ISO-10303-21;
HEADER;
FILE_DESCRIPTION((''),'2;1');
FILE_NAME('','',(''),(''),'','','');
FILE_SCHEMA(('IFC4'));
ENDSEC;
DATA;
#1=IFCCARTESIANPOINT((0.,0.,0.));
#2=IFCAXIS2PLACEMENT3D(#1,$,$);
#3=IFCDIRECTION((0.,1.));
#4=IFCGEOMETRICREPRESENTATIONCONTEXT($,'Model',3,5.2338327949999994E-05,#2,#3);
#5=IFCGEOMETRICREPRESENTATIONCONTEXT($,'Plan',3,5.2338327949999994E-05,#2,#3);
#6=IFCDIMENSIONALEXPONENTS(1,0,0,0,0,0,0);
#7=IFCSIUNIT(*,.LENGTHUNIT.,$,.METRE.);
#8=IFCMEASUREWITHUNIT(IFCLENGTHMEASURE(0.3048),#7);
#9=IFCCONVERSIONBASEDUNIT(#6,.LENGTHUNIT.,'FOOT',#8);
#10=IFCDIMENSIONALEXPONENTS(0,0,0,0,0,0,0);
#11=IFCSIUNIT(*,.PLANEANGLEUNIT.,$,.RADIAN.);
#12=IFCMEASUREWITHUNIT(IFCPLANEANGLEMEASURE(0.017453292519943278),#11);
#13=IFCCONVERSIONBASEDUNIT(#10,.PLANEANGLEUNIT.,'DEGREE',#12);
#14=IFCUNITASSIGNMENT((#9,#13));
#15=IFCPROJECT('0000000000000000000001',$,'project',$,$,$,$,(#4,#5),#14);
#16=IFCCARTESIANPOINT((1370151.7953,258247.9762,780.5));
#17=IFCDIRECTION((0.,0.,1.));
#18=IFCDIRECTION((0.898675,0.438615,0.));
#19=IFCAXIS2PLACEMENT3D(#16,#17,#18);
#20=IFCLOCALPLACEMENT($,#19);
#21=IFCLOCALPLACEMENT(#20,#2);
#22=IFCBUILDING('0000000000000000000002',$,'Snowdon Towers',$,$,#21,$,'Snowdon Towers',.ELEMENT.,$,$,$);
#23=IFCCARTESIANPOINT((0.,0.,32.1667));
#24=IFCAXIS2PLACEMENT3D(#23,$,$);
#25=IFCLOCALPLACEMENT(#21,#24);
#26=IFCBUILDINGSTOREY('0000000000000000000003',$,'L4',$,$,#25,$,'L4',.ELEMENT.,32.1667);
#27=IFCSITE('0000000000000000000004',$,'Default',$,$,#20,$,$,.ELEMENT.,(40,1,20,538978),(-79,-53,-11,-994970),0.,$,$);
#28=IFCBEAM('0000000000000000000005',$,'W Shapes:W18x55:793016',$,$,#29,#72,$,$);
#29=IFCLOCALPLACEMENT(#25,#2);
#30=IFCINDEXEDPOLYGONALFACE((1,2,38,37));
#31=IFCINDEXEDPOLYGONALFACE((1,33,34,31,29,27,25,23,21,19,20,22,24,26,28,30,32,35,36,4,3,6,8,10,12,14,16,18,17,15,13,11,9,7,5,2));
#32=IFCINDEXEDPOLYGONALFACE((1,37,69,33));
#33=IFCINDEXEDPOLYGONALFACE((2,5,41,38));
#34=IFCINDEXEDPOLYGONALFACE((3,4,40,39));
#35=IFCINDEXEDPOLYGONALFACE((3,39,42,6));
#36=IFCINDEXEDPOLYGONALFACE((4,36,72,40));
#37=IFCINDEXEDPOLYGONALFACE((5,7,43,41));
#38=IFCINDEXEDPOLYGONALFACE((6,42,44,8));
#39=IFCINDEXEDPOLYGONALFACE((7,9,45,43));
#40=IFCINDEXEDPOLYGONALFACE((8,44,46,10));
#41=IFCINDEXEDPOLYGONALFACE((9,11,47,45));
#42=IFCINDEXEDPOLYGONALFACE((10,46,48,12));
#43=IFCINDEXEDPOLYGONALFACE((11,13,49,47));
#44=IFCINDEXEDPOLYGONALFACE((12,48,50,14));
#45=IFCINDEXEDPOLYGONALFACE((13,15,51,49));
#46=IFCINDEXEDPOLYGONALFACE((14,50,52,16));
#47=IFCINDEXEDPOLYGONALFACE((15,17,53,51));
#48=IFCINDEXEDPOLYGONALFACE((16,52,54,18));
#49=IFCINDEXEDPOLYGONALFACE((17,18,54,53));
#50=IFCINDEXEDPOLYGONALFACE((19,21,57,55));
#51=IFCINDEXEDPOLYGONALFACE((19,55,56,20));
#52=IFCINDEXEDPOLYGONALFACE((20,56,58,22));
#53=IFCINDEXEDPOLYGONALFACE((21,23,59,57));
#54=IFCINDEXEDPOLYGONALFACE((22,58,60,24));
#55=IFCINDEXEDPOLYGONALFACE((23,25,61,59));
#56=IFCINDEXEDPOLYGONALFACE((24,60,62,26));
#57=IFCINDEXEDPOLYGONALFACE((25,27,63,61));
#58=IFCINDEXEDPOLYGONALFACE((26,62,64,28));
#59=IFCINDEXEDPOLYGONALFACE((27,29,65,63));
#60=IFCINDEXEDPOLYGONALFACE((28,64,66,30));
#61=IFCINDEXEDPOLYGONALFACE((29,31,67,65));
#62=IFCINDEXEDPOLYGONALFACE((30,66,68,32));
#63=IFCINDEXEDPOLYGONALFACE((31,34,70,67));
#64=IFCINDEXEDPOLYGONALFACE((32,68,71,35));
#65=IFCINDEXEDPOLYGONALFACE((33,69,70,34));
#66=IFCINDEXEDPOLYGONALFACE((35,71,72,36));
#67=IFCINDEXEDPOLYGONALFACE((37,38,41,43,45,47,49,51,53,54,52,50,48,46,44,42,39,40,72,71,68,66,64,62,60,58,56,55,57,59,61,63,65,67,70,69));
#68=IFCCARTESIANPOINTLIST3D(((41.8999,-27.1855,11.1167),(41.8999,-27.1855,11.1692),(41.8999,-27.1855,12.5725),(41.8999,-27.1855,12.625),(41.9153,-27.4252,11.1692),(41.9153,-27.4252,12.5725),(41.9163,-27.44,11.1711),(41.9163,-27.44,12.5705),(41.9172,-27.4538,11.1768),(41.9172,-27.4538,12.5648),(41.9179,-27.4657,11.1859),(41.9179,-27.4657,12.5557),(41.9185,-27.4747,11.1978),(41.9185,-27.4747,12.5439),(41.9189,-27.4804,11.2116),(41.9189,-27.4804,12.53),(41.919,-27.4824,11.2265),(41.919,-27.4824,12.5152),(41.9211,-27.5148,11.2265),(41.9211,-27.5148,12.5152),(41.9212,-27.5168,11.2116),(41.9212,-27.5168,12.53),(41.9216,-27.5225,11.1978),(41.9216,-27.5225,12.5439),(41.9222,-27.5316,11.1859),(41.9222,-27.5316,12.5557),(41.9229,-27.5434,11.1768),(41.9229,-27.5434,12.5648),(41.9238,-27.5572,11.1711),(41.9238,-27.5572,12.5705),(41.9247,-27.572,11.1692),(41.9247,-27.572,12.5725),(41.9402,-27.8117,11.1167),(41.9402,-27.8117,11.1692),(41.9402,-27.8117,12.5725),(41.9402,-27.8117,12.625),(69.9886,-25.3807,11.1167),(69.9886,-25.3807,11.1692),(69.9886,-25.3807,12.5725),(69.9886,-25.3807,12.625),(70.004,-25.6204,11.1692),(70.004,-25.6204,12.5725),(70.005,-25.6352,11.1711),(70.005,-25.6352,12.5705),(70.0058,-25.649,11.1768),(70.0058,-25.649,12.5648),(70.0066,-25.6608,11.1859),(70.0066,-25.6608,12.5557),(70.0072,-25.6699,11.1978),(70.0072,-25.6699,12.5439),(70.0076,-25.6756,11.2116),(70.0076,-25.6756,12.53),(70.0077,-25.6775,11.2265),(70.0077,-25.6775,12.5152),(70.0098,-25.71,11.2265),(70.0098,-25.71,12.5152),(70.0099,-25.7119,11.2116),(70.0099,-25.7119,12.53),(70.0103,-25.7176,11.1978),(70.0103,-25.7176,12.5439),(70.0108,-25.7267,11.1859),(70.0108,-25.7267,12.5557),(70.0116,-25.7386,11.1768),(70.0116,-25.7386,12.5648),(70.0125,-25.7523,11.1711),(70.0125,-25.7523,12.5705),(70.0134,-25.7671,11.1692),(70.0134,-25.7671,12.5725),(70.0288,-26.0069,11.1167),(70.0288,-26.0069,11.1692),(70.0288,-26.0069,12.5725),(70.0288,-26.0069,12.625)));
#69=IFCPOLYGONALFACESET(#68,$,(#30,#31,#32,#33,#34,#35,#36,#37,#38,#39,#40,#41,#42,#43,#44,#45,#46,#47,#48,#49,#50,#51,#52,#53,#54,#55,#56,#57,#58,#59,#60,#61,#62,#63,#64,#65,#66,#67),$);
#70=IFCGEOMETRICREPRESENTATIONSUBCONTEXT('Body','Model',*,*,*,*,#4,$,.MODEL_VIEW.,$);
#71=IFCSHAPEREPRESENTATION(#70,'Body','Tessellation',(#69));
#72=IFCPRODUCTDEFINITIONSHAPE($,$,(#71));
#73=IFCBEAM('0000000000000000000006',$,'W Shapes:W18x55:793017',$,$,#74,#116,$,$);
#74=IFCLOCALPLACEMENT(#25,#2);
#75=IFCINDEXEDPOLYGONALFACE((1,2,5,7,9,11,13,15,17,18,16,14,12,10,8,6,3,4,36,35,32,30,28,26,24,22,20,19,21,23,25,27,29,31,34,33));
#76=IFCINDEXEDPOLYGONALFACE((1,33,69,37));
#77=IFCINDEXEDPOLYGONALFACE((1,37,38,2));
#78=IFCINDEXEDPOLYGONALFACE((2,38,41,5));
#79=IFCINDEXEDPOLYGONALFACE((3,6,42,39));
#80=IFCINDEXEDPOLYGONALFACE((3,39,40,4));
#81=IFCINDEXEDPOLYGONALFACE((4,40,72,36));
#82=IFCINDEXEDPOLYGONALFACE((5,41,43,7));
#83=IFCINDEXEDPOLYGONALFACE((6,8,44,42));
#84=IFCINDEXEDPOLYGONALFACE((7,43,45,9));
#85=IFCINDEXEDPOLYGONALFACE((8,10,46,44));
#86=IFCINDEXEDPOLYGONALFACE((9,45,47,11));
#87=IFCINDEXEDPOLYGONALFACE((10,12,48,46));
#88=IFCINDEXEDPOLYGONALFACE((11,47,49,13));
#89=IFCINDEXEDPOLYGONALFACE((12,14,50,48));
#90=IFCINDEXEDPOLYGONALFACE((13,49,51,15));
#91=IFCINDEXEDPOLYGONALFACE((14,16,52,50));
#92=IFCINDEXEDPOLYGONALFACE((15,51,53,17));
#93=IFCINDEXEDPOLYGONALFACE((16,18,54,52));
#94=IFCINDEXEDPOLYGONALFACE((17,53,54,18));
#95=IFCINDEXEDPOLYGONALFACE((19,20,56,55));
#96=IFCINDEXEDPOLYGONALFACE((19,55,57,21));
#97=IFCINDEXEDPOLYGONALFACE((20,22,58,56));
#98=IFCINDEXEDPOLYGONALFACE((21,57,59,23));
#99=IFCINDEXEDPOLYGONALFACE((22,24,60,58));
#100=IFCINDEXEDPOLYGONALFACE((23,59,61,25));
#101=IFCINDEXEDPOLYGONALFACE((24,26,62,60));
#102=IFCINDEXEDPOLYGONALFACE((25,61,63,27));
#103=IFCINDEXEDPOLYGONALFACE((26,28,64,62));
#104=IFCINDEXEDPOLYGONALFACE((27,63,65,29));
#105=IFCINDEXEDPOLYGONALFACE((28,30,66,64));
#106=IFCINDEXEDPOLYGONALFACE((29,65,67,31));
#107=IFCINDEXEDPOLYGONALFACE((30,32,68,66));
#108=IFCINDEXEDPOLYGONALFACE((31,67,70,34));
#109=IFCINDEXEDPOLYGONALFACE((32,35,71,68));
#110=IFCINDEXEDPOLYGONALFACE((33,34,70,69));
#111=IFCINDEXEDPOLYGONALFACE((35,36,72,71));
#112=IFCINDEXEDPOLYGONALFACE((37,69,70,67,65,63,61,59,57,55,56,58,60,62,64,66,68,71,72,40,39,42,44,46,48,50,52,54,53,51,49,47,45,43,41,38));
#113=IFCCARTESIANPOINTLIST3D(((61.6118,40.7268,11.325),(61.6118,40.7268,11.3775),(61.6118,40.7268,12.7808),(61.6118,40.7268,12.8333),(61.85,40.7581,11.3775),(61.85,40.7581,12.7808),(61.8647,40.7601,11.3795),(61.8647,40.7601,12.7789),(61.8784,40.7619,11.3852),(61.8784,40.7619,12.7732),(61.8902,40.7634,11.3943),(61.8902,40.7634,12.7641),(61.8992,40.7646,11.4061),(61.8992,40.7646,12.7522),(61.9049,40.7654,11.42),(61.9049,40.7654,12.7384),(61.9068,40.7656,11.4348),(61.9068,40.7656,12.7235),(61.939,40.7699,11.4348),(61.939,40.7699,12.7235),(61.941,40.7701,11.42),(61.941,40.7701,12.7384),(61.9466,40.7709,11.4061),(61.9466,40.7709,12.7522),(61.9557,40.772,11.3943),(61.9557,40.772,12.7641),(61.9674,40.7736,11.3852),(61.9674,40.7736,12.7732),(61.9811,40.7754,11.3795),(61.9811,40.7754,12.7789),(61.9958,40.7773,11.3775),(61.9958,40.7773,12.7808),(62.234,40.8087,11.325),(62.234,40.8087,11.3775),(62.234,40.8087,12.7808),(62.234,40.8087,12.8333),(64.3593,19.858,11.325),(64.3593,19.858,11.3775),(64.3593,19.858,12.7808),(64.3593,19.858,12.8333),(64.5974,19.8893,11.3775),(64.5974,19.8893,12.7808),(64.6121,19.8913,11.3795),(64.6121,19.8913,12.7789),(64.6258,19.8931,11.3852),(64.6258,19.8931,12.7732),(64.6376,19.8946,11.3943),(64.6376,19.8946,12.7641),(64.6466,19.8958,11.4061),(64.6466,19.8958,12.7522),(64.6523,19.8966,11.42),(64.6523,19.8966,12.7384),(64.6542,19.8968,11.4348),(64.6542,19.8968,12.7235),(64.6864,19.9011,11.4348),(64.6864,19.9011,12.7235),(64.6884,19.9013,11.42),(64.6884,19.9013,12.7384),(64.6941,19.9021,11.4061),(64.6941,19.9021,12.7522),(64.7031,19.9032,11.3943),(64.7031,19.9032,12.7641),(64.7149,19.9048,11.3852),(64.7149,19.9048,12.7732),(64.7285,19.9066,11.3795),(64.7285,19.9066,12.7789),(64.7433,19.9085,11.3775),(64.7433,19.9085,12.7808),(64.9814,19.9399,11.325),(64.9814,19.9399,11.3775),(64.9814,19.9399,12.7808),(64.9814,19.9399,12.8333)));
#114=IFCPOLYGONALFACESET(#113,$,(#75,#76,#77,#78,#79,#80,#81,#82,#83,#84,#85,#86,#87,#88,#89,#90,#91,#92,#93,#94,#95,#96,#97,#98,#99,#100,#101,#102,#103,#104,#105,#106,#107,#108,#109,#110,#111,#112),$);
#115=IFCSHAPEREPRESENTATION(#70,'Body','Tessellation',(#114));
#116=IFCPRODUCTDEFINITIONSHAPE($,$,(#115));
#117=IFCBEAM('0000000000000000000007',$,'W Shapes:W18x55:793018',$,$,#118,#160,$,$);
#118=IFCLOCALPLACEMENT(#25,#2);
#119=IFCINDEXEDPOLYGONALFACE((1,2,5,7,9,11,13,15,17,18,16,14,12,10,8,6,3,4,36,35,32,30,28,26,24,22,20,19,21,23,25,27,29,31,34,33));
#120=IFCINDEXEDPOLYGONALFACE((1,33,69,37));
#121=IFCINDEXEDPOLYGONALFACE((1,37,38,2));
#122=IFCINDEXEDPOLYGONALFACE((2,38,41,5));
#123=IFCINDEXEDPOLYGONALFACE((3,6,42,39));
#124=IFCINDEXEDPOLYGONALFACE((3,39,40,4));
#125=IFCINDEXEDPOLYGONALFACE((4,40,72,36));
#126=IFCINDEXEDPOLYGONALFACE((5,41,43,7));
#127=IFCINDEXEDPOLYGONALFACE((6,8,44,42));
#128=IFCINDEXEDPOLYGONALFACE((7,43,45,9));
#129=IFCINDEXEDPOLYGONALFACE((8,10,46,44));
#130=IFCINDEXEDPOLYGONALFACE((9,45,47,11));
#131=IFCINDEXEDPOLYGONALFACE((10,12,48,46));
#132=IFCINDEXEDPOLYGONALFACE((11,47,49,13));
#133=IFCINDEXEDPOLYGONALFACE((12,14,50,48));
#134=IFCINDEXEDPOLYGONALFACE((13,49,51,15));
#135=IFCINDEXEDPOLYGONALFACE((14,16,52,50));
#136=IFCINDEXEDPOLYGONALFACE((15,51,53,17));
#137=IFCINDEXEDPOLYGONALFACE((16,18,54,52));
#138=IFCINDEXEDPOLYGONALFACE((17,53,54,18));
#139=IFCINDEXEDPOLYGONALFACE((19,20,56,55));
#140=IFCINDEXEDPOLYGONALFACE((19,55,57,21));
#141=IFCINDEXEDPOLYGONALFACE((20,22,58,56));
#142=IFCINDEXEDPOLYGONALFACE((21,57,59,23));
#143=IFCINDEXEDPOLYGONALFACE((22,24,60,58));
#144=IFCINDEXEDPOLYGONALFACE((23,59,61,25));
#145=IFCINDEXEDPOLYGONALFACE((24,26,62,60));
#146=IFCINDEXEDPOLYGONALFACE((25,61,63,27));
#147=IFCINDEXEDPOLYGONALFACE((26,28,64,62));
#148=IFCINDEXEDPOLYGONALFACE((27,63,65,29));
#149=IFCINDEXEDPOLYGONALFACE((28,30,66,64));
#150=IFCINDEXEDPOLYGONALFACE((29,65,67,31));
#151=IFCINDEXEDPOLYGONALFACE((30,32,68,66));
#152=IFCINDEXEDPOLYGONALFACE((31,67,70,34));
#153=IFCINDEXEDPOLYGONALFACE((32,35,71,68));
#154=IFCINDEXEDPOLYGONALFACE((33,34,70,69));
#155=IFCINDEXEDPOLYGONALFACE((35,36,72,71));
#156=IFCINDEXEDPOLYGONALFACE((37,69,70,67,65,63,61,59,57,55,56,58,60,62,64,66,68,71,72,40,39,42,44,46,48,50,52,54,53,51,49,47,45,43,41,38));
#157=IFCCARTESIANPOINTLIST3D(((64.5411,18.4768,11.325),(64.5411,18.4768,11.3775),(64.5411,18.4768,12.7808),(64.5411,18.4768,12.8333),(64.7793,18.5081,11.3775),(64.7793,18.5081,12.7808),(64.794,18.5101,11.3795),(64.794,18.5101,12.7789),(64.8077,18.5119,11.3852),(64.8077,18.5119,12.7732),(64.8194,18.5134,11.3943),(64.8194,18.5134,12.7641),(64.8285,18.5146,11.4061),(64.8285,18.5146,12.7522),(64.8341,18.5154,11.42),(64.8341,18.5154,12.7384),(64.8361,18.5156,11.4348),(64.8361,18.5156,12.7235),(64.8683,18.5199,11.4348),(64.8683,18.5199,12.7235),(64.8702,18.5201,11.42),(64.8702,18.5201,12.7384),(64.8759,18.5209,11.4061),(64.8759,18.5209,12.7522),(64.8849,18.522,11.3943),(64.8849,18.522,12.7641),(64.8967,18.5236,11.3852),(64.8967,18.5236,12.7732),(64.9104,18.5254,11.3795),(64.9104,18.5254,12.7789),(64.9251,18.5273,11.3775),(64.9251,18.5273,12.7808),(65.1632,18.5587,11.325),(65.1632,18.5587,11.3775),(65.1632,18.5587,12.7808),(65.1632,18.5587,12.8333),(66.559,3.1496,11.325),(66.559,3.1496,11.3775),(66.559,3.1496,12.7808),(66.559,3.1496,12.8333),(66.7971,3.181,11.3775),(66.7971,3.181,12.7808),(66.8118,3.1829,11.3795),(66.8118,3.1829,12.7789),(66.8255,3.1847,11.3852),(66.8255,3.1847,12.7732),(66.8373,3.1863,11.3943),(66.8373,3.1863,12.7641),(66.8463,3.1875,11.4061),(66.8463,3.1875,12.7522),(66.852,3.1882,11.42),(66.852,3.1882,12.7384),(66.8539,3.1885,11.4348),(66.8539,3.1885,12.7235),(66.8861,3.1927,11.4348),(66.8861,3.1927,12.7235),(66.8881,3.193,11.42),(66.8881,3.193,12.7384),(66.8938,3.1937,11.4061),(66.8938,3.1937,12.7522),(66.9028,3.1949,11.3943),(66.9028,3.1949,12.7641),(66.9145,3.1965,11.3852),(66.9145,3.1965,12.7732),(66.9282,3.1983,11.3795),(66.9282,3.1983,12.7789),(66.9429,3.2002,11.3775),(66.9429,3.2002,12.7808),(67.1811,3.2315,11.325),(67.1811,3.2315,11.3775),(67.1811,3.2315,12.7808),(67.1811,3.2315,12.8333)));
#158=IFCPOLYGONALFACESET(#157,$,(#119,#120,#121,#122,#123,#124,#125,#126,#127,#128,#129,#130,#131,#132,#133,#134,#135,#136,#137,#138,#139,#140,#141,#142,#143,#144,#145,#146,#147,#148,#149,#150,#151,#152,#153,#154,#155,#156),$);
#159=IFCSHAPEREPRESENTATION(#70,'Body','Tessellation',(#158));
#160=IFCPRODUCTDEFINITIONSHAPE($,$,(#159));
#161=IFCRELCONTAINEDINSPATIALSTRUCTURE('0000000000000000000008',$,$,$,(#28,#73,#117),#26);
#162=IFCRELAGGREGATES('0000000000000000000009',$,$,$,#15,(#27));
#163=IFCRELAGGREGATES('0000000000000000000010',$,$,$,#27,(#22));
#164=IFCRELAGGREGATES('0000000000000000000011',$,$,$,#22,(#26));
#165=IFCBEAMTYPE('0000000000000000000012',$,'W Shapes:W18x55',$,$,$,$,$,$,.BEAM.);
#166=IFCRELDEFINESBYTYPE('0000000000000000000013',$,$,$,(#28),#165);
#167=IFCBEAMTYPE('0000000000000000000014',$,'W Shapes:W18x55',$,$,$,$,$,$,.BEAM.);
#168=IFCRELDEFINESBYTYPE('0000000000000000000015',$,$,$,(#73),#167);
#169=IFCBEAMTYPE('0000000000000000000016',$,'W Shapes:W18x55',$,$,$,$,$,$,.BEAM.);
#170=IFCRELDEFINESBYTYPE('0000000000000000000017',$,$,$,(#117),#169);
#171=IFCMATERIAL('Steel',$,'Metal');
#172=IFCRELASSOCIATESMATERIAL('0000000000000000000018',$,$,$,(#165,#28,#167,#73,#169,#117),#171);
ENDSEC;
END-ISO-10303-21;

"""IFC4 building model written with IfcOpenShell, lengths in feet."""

from ifc_helpers import new_model, entity, si_unit, converted_unit, direction, frame, origin, place, context, subcontext, project, spatial, line, arc, indexed_curve, outline, extrude, source, transform, mapped, material, type_object, type_shapes, element, save


model = new_model("IFC4")

# Units and contexts
model_context = context("Model", 3, precision=5.2338327949999994e-05, world=origin(), true_north=direction((0.0, 1.0)))
plan_context = context("Plan", 3, precision=5.2338327949999994e-05, world=origin(), true_north=direction((0.0, 1.0)))
body_context = subcontext(model_context, "Body", "Model", "MODEL_VIEW")
ifc_project = project(units=[converted_unit("LENGTHUNIT", "FOOT", entity("IfcLengthMeasure", 0.3048), si_unit("LENGTHUNIT", "METRE"), dimensions=[1, 0, 0, 0, 0, 0, 0]), converted_unit("PLANEANGLEUNIT", "DEGREE", entity("IfcPlaneAngleMeasure", 0.017453292519943278), si_unit("PLANEANGLEUNIT", "RADIAN"), dimensions=[0, 0, 0, 0, 0, 0, 0])], contexts=[model_context, plan_context])

# Site, building, storey
site_placement = place(None, frame((1370151.7953, 258247.9762, 780.5), z_axis=(0.0, 0.0, 1.0), x_axis=(0.898675, 0.438615, 0.0)))
site = spatial("IfcSite", under=ifc_project, at=site_placement, Name="Default", CompositionType="ELEMENT", RefLatitude=(40, 1, 20, 538978), RefLongitude=(-79, -53, -11, -994970), RefElevation=0.0)
building_placement = place(site_placement, origin())
building = spatial("IfcBuilding", under=site, at=building_placement, Name="Snowdon Towers", LongName="Snowdon Towers", CompositionType="ELEMENT")
storey_placement = place(building_placement, frame((0.0, 0.0, 32.1667)))
storey = spatial("IfcBuildingStorey", under=building, at=storey_placement, Name="L4", LongName="L4", CompositionType="ELEMENT", Elevation=32.1667)

# Beams
ifc_material = material(Name="Steel", Category="Metal")
beam_type_1 = type_object("IfcBeamType", Name="W Shapes:W18x55", PredefinedType="BEAM", material=ifc_material)
shared_shape_1 = source(origin(), body_context, "Body", "SweptSolid", [
    extrude(outline(indexed_curve([(-0.7542, -0.3137), (-0.7017, -0.3137), (-0.7017, -0.0735), (-0.6849, -0.033), (-0.6444, -0.0162), (0.6444, -0.0163), (0.6849, -0.033), (0.7017, -0.0735), (0.7017, -0.3138), (0.7542, -0.3138), (0.7542, 0.3137), (0.7017, 0.3137), (0.7017, 0.0735), (0.6849, 0.033), (0.6444, 0.0162), (-0.6444, 0.0163), (-0.6849, 0.033), (-0.7017, 0.0735), (-0.7017, 0.3138), (-0.7542, 0.3138)], segments=[line(1, 2, 3), arc(3, 4, 5), line(5, 6), arc(6, 7, 8), line(8, 9, 10, 11, 12, 13), arc(13, 14, 15), line(15, 16), arc(16, 17, 18), line(18, 19, 20, 1)], self_intersect=False)), frame((-14.3614, 0.0, 0.0), z_axis=(1.0, 0.0, 0.0), x_axis=(0.0, 0.0, -1.0)), (0.0, 0.0, 1.0), 28.1466),
])
type_shapes(beam_type_1, [shared_shape_1])
beam_1_placement = place(storey_placement, frame((56.2518, -26.5777, 11.8708), z_axis=(0.0, 0.0, 1.0), x_axis=(0.997942, 0.064123, 0.0)))
element("IfcBeam", 1, at=beam_1_placement, inside=storey, type_object=beam_type_1, material=ifc_material, Name="W Shapes:W18x55:793016", context=body_context, shape_type="MappedRepresentation", body=[
    mapped(shared_shape_1, transform((0.0, 0.0, 0.0), scale=1.0)),
])
beam_type_2 = type_object("IfcBeamType", Name="W Shapes:W18x55", PredefinedType="BEAM", material=ifc_material)
shared_shape_2 = source(origin(), body_context, "Body", "SweptSolid", [
    extrude(outline(indexed_curve([(-0.7542, -0.3138), (-0.7017, -0.3138), (-0.7017, -0.0735), (-0.6849, -0.033), (-0.6444, -0.0162), (0.6444, -0.0162), (0.6849, -0.033), (0.7017, -0.0735), (0.7017, -0.3138), (0.7542, -0.3138), (0.7542, 0.3138), (0.7017, 0.3138), (0.7017, 0.0735), (0.6849, 0.033), (0.6444, 0.0163), (-0.6444, 0.0163), (-0.6849, 0.033), (-0.7017, 0.0735), (-0.7017, 0.3137), (-0.7542, 0.3137)], segments=[line(1, 2, 3), arc(3, 4, 5), line(5, 6), arc(6, 7, 8), line(8, 9, 10, 11, 12, 13), arc(13, 14, 15), line(15, 16), arc(16, 17, 18), line(18, 19, 20, 1)], self_intersect=False)), frame((-10.5172, 0.0, 0.0), z_axis=(1.0, 0.0, 0.0), x_axis=(0.0, 0.0, -1.0)), (0.0, 0.0, 1.0), 21.0489),
])
type_shapes(beam_type_2, [shared_shape_2])
beam_2_placement = place(storey_placement, frame((63.2957, 30.3405, 12.0792), z_axis=(0.0, 0.0, 1.0), x_axis=(0.130526, -0.991445, 0.0)))
element("IfcBeam", 2, at=beam_2_placement, inside=storey, type_object=beam_type_2, material=ifc_material, Name="W Shapes:W18x55:793017", context=body_context, shape_type="MappedRepresentation", body=[
    mapped(shared_shape_2, transform((0.0, 0.0, 0.0), scale=1.0)),
])
beam_type_3 = type_object("IfcBeamType", Name="W Shapes:W18x55", PredefinedType="BEAM", material=ifc_material)
shared_shape_3 = source(origin(), body_context, "Body", "SweptSolid", [
    extrude(outline(indexed_curve([(-0.7542, -0.3138), (-0.7017, -0.3138), (-0.7017, -0.0735), (-0.6849, -0.033), (-0.6444, -0.0162), (0.6444, -0.0162), (0.6849, -0.033), (0.7017, -0.0735), (0.7017, -0.3138), (0.7542, -0.3138), (0.7542, 0.3138), (0.7017, 0.3138), (0.7017, 0.0735), (0.6849, 0.033), (0.6444, 0.0163), (-0.6444, 0.0163), (-0.6849, 0.033), (-0.7017, 0.0735), (-0.7017, 0.3137), (-0.7542, 0.3137)], segments=[line(1, 2, 3), arc(3, 4, 5), line(5, 6), arc(6, 7, 8), line(8, 9, 10, 11, 12, 13), arc(13, 14, 15), line(15, 16), arc(16, 17, 18), line(18, 19, 20, 1)], self_intersect=False)), frame((-7.8065, 0.0, 0.0), z_axis=(1.0, 0.0, 0.0), x_axis=(0.0, 0.0, -1.0)), (0.0, 0.0, 1.0), 15.4594),
])
type_shapes(beam_type_3, [shared_shape_3])
beam_3_placement = place(storey_placement, frame((65.8711, 10.778, 12.0792), z_axis=(0.0, 0.0, 1.0), x_axis=(0.130526, -0.991445, 0.0)))
element("IfcBeam", 3, at=beam_3_placement, inside=storey, type_object=beam_type_3, material=ifc_material, Name="W Shapes:W18x55:793018", context=body_context, shape_type="MappedRepresentation", body=[
    mapped(shared_shape_3, transform((0.0, 0.0, 0.0), scale=1.0)),
])

save(model, "model.ifc")
